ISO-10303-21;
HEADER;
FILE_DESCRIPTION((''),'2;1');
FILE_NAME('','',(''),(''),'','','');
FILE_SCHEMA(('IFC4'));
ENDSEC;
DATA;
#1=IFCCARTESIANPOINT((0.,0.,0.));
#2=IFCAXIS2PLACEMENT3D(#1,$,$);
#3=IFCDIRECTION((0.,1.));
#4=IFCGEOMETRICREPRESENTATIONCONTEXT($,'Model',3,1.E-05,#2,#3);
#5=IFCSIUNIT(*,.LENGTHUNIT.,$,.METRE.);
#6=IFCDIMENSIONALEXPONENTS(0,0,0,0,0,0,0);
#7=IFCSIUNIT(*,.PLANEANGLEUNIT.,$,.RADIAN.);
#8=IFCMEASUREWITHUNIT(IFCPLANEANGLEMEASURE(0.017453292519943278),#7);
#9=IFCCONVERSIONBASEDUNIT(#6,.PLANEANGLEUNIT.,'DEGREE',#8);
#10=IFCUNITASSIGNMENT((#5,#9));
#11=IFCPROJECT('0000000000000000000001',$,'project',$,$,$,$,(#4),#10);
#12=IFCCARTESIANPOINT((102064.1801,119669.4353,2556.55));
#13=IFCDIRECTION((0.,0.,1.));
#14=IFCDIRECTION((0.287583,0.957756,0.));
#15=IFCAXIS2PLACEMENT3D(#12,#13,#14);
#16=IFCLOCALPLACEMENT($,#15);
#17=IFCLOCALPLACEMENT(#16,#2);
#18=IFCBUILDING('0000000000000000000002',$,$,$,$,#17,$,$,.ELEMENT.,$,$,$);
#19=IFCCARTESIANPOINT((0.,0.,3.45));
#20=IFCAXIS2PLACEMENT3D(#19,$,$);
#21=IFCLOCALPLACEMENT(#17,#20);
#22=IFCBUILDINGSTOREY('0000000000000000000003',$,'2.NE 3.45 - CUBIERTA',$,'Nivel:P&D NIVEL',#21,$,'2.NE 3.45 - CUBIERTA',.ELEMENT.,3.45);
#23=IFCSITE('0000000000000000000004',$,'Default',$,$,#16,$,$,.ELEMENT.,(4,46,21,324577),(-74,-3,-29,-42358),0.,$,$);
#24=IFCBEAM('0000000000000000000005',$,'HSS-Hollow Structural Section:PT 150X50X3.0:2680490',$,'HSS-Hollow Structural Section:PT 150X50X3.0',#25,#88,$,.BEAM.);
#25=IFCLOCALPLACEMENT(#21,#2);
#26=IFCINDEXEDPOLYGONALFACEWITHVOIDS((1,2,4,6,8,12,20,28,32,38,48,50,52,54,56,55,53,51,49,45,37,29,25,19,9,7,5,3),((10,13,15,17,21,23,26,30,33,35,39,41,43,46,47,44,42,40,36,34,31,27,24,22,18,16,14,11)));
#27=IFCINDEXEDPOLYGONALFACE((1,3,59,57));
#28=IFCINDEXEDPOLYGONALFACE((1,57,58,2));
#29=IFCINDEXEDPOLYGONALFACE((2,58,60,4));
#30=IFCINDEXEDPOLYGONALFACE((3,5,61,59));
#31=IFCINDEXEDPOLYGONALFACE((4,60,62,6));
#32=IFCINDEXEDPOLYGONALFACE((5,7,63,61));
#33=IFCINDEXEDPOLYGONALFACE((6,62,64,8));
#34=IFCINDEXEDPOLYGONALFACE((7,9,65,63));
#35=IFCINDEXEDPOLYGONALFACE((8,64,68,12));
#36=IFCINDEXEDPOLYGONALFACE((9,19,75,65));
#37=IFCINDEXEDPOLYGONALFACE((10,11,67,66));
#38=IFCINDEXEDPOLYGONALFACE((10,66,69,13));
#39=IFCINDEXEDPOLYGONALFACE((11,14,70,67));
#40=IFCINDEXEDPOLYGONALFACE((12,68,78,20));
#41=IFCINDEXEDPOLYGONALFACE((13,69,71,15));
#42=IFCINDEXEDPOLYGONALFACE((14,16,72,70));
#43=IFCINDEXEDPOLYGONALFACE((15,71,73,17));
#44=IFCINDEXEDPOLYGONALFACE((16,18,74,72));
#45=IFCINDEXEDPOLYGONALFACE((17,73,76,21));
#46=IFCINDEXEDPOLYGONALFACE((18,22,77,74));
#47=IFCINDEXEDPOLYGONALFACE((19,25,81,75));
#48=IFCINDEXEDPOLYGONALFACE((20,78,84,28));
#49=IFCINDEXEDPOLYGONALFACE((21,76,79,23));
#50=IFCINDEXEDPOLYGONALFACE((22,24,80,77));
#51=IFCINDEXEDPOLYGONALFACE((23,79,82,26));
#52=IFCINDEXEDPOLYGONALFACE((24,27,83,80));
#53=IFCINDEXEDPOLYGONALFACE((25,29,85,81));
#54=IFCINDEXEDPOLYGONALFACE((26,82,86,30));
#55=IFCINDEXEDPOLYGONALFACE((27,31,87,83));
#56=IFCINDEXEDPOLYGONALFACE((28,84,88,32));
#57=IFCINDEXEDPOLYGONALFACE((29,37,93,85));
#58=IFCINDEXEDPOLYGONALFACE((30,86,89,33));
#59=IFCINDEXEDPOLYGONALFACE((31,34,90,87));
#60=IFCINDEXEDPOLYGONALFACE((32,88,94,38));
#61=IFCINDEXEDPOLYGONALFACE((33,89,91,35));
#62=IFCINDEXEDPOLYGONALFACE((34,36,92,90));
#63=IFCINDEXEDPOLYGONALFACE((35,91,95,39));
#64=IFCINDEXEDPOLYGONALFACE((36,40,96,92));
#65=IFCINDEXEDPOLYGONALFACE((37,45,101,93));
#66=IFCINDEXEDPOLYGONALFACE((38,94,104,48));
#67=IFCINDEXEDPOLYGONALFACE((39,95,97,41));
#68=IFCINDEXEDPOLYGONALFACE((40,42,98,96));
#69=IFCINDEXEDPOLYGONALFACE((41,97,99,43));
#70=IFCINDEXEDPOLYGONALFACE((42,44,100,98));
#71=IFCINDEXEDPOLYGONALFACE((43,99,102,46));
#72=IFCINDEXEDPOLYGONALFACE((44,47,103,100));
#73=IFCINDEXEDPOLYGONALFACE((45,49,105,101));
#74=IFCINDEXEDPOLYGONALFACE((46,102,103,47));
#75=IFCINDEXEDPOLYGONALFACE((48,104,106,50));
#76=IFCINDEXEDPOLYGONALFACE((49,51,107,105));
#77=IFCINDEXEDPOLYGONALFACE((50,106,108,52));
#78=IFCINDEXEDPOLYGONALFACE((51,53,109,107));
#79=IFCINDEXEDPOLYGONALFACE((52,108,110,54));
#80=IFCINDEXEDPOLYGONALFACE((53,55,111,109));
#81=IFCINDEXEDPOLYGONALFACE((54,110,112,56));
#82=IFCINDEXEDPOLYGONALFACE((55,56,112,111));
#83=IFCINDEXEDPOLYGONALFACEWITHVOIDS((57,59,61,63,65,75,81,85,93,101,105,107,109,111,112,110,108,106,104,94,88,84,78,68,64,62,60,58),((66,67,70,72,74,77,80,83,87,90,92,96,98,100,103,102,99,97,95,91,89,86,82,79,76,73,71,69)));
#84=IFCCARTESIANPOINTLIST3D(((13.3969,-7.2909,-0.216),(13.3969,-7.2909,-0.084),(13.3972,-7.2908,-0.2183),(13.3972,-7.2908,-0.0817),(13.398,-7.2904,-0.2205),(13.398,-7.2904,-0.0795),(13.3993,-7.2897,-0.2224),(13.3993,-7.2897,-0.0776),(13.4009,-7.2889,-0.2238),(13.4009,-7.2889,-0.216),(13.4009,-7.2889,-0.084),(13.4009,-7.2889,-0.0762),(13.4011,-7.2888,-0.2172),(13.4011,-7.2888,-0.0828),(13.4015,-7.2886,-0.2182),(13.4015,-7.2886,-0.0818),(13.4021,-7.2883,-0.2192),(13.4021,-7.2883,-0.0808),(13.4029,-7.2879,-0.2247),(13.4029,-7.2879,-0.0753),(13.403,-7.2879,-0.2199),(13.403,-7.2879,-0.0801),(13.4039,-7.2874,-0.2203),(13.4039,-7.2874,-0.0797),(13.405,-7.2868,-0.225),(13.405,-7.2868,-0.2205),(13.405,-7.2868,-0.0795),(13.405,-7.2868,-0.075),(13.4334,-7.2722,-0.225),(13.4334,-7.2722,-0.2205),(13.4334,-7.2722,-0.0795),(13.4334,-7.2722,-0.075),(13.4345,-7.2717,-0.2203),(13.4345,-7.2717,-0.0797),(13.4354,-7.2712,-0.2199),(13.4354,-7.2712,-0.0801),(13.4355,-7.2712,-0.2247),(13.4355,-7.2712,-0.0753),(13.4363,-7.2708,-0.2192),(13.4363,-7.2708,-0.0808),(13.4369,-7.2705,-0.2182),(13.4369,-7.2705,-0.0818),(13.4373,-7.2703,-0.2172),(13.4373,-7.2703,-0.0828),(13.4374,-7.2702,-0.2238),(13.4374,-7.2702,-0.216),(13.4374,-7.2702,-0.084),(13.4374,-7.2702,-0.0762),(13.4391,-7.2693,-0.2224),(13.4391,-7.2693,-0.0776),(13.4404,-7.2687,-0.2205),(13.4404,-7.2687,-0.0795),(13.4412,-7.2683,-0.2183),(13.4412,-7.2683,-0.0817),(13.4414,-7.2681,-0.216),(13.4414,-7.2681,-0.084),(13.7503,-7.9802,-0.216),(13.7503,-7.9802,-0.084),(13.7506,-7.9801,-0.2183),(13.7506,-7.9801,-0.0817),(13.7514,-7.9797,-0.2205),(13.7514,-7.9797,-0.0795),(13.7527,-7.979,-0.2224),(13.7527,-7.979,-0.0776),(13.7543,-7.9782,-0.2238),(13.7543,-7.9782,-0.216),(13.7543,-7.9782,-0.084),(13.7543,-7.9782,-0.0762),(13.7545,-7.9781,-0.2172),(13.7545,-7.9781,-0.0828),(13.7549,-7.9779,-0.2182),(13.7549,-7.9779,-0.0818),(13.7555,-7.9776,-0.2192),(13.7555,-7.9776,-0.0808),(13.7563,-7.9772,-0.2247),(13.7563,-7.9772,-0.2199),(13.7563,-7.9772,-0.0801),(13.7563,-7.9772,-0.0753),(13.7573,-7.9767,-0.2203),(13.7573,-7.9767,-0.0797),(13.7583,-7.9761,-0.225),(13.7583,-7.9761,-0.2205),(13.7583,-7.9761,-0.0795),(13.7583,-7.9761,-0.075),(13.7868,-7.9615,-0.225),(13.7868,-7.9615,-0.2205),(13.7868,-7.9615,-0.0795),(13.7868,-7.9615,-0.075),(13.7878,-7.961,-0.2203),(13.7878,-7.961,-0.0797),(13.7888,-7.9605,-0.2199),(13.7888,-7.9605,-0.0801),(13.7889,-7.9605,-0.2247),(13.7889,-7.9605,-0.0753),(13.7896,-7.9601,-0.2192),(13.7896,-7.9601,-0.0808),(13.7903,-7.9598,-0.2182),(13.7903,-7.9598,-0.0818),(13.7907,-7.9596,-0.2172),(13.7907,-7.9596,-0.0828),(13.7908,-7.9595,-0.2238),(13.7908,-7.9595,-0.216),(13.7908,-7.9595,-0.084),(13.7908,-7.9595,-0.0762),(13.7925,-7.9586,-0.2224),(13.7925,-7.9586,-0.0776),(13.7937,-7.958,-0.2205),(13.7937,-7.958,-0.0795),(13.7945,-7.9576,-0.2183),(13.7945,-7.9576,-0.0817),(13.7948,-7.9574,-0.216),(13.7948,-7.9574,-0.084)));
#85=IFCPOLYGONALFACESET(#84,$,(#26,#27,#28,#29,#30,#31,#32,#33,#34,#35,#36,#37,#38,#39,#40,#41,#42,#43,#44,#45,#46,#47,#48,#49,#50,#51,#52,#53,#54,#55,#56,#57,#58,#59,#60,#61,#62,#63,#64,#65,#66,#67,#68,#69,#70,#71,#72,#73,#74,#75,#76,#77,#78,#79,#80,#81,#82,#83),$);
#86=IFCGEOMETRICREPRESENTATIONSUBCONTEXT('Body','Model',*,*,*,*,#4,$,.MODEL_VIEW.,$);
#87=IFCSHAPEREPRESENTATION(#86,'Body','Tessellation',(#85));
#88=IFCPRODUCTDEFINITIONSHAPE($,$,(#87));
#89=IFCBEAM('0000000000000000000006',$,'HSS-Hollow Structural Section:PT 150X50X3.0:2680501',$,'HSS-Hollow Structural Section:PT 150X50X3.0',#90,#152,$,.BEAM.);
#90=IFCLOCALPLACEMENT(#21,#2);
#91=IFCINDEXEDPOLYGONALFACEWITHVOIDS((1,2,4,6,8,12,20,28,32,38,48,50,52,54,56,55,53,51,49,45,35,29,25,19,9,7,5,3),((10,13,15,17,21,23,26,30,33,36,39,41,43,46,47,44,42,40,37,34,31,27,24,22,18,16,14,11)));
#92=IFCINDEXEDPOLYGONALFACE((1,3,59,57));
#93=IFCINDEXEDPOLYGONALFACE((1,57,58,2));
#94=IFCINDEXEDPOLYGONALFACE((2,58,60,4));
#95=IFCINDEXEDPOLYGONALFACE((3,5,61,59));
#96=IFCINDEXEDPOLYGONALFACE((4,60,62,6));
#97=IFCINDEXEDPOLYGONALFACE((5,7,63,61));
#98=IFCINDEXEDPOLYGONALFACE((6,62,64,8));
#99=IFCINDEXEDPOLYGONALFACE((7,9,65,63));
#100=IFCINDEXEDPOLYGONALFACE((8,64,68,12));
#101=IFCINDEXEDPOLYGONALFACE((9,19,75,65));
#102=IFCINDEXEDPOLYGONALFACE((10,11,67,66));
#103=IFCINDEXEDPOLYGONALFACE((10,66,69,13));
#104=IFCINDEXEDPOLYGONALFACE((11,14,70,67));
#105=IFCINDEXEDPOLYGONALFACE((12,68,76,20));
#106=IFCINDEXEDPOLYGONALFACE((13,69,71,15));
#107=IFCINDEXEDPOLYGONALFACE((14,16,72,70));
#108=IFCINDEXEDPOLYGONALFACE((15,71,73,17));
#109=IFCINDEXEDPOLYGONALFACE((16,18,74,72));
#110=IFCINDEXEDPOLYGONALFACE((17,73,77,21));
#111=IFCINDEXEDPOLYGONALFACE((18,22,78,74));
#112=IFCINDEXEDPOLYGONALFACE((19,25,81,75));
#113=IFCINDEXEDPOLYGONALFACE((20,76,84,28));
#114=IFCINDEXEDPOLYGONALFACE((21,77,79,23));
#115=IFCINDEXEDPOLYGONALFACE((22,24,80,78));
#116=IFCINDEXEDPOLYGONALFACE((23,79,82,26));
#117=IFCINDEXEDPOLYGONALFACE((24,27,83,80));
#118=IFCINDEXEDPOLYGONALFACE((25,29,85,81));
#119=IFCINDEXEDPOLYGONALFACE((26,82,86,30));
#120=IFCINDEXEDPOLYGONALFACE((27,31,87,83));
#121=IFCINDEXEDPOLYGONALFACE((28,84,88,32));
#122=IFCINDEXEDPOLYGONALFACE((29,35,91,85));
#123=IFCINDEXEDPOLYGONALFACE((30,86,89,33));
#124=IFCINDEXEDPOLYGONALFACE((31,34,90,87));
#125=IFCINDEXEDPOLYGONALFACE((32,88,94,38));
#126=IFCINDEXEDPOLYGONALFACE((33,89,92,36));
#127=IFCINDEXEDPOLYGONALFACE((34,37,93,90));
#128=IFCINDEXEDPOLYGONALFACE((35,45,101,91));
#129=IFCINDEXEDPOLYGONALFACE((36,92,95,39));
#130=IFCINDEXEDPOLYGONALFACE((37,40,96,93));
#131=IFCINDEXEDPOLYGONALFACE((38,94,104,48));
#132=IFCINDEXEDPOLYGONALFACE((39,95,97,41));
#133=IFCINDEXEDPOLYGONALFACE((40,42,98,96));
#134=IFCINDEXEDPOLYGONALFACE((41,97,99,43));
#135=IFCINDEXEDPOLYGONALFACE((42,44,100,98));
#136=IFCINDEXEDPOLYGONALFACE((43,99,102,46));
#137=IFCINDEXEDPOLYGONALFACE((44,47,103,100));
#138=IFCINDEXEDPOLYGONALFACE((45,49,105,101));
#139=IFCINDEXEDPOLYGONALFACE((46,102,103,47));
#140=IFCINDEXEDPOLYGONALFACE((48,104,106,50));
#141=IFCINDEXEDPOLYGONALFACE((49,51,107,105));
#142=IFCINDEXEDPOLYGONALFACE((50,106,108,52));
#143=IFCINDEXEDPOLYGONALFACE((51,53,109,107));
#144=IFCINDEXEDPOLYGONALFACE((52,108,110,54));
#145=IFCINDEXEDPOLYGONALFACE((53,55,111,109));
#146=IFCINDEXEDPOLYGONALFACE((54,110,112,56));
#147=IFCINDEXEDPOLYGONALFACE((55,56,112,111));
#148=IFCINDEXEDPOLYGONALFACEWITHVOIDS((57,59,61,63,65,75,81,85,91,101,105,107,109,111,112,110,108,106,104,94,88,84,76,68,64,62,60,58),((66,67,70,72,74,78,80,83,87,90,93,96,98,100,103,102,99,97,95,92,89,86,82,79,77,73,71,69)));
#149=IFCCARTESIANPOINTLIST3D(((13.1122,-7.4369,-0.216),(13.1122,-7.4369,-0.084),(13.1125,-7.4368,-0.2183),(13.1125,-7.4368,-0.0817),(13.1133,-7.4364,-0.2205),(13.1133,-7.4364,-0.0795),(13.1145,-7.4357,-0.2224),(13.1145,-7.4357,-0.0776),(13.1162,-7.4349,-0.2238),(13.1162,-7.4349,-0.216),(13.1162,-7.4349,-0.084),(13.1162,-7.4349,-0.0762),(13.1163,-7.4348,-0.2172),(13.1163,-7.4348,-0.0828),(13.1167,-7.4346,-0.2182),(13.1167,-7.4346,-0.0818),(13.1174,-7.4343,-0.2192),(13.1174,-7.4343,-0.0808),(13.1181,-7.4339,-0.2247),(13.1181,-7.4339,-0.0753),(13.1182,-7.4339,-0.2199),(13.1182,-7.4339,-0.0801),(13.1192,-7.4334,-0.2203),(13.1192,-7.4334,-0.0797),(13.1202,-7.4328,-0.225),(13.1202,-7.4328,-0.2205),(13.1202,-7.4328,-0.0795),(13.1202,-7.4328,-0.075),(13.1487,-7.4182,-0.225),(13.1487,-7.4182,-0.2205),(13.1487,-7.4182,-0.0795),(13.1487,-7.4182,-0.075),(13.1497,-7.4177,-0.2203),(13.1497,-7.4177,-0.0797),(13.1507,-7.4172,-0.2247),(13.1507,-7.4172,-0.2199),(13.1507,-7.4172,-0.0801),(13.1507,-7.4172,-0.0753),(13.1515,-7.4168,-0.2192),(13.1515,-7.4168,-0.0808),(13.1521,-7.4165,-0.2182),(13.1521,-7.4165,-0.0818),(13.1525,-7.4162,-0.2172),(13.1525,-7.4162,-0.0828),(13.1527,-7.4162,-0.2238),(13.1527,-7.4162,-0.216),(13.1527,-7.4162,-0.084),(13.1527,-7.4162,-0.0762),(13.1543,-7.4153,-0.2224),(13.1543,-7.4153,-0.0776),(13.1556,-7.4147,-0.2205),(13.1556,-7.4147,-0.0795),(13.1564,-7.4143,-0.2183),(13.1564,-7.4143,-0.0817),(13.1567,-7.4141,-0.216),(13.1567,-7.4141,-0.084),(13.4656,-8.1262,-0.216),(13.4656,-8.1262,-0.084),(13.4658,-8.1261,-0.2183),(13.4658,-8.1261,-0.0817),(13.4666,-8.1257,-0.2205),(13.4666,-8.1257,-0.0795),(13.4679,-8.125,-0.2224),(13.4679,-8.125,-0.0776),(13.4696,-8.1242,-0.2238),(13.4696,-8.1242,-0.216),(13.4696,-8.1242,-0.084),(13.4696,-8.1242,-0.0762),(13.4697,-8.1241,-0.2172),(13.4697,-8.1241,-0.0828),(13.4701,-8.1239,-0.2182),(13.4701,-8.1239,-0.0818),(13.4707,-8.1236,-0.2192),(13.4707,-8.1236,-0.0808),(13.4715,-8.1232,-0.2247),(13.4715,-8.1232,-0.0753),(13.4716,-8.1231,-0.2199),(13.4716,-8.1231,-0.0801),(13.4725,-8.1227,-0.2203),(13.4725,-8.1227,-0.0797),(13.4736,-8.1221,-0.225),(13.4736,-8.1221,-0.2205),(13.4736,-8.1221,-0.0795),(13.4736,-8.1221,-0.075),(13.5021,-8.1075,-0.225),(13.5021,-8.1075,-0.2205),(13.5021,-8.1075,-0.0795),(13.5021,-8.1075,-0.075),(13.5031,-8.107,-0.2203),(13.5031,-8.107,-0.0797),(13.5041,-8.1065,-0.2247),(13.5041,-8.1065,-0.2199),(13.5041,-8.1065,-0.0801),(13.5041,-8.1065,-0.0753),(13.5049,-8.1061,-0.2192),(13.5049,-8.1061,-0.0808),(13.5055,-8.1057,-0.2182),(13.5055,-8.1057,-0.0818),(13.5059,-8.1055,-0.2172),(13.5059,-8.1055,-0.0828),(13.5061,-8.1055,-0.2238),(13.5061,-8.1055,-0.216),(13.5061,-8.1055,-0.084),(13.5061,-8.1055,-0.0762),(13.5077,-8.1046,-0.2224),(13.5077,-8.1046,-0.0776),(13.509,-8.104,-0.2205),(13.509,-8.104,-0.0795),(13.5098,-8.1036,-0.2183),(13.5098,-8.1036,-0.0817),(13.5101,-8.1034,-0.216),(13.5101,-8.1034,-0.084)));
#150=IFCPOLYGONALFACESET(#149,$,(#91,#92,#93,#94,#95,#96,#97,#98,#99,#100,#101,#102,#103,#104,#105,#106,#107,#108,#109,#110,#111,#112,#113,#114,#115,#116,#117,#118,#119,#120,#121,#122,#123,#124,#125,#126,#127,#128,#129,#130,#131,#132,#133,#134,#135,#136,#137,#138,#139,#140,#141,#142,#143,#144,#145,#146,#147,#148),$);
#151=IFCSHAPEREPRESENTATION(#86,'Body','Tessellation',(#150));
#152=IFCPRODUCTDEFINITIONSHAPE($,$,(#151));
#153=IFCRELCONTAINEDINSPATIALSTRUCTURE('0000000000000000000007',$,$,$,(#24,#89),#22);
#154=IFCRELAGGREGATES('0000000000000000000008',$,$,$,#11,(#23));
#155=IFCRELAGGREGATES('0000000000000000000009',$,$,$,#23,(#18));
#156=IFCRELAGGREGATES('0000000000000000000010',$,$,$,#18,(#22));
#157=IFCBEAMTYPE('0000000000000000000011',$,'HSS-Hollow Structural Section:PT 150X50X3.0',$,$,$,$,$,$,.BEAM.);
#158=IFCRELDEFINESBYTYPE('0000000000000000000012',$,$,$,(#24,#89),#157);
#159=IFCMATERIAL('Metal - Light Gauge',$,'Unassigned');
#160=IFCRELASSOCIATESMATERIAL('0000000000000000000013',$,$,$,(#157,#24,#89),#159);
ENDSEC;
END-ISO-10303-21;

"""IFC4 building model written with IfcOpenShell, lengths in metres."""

from ifc_helpers import new_model, entity, si_unit, converted_unit, direction, frame, origin, place, context, subcontext, project, spatial, line, arc, indexed_curve, outline, extrude, source, transform, mapped, material, type_object, type_shapes, element, save


model = new_model("IFC4")

# Units and contexts
model_context = context("Model", 3, precision=1e-05, world=origin(), true_north=direction((0.0, 1.0)))
body_context = subcontext(model_context, "Body", "Model", "MODEL_VIEW")
ifc_project = project(units=[si_unit("LENGTHUNIT", "METRE"), converted_unit("PLANEANGLEUNIT", "DEGREE", entity("IfcPlaneAngleMeasure", 0.017453292519943278), si_unit("PLANEANGLEUNIT", "RADIAN"), dimensions=[0, 0, 0, 0, 0, 0, 0])], contexts=[model_context])

# Site, building, storey
site_placement = place(None, frame((102064.1801, 119669.4353, 2556.55), z_axis=(0.0, 0.0, 1.0), x_axis=(0.287583, 0.957756, 0.0)))
site = spatial("IfcSite", under=ifc_project, at=site_placement, Name="Default", CompositionType="ELEMENT", RefLatitude=(4, 46, 21, 324577), RefLongitude=(-74, -3, -29, -42358), RefElevation=0.0)
building_placement = place(site_placement, origin())
building = spatial("IfcBuilding", under=site, at=building_placement, CompositionType="ELEMENT")
storey_placement = place(building_placement, frame((0.0, 0.0, 3.45)))
storey = spatial("IfcBuildingStorey", under=building, at=storey_placement, Name="2.NE 3.45 - CUBIERTA", ObjectType="Nivel:P&D NIVEL", LongName="2.NE 3.45 - CUBIERTA", CompositionType="ELEMENT", Elevation=3.45)

# Beams
ifc_material_1 = material(Name="Metal - Light Gauge", Category="Unassigned")
beam_type_1 = type_object("IfcBeamType", Name="HSS-Hollow Structural Section:PT 150X50X3.0", PredefinedType="BEAM", material=ifc_material_1)
shared_shape_1 = source(origin(), body_context, "Body", "SweptSolid", [
    extrude(outline(indexed_curve([(-0.025, -0.066), (-0.0224, -0.0724), (-0.016, -0.075), (0.016, -0.075), (0.0224, -0.0724), (0.025, -0.066), (0.025, 0.066), (0.0224, 0.0724), (0.016, 0.075), (-0.016, 0.075), (-0.0224, 0.0724), (-0.025, 0.066)], segments=[arc(1, 2, 3), line(3, 4), arc(4, 5, 6), line(6, 7), arc(7, 8, 9), line(9, 10), arc(10, 11, 12), line(12, 1)], self_intersect=False), holes=[indexed_curve([(0.016, -0.0705), (-0.016, -0.0705), (-0.0192, -0.0692), (-0.0205, -0.066), (-0.0205, 0.066), (-0.0192, 0.0692), (-0.016, 0.0705), (0.016, 0.0705), (0.0192, 0.0692), (0.0205, 0.066), (0.0205, -0.066), (0.0192, -0.0692)], segments=[line(1, 2), arc(2, 3, 4), line(4, 5), arc(5, 6, 7), line(7, 8), arc(8, 9, 10), line(10, 11), arc(11, 12, 1)], self_intersect=False)]), frame((-0.3873, 0.0, 0.0), z_axis=(1.0, 0.0, 0.0), x_axis=(0.0, -1.0, 0.0)), (0.0, 0.0, 1.0), 0.7746),
])
type_shapes(beam_type_1, [shared_shape_1])
for number, where, z_axis, x_axis, name in (
    (1, (13.5959, -7.6242, -0.15), (0.0, 0.0, 1.0), (-0.456217, 0.889869, 0.0), "HSS-Hollow Structural Section:PT 150X50X3.0:2680490"),
    (2, (13.3111, -7.7702, -0.15), (0.0, 0.0, 1.0), (-0.456217, 0.889869, 0.0), "HSS-Hollow Structural Section:PT 150X50X3.0:2680501"),
):
    element("IfcBeam", number, at=place(storey_placement, frame(where, z_axis=z_axis, x_axis=x_axis)), inside=storey, type_object=beam_type_1, material=ifc_material_1, Name=name, ObjectType="HSS-Hollow Structural Section:PT 150X50X3.0", PredefinedType="BEAM", context=body_context, shape_type="MappedRepresentation", body=[
        mapped(shared_shape_1, transform((0.0, 0.0, 0.0), scale=1.0)),
    ])

save(model, "model.ifc")
